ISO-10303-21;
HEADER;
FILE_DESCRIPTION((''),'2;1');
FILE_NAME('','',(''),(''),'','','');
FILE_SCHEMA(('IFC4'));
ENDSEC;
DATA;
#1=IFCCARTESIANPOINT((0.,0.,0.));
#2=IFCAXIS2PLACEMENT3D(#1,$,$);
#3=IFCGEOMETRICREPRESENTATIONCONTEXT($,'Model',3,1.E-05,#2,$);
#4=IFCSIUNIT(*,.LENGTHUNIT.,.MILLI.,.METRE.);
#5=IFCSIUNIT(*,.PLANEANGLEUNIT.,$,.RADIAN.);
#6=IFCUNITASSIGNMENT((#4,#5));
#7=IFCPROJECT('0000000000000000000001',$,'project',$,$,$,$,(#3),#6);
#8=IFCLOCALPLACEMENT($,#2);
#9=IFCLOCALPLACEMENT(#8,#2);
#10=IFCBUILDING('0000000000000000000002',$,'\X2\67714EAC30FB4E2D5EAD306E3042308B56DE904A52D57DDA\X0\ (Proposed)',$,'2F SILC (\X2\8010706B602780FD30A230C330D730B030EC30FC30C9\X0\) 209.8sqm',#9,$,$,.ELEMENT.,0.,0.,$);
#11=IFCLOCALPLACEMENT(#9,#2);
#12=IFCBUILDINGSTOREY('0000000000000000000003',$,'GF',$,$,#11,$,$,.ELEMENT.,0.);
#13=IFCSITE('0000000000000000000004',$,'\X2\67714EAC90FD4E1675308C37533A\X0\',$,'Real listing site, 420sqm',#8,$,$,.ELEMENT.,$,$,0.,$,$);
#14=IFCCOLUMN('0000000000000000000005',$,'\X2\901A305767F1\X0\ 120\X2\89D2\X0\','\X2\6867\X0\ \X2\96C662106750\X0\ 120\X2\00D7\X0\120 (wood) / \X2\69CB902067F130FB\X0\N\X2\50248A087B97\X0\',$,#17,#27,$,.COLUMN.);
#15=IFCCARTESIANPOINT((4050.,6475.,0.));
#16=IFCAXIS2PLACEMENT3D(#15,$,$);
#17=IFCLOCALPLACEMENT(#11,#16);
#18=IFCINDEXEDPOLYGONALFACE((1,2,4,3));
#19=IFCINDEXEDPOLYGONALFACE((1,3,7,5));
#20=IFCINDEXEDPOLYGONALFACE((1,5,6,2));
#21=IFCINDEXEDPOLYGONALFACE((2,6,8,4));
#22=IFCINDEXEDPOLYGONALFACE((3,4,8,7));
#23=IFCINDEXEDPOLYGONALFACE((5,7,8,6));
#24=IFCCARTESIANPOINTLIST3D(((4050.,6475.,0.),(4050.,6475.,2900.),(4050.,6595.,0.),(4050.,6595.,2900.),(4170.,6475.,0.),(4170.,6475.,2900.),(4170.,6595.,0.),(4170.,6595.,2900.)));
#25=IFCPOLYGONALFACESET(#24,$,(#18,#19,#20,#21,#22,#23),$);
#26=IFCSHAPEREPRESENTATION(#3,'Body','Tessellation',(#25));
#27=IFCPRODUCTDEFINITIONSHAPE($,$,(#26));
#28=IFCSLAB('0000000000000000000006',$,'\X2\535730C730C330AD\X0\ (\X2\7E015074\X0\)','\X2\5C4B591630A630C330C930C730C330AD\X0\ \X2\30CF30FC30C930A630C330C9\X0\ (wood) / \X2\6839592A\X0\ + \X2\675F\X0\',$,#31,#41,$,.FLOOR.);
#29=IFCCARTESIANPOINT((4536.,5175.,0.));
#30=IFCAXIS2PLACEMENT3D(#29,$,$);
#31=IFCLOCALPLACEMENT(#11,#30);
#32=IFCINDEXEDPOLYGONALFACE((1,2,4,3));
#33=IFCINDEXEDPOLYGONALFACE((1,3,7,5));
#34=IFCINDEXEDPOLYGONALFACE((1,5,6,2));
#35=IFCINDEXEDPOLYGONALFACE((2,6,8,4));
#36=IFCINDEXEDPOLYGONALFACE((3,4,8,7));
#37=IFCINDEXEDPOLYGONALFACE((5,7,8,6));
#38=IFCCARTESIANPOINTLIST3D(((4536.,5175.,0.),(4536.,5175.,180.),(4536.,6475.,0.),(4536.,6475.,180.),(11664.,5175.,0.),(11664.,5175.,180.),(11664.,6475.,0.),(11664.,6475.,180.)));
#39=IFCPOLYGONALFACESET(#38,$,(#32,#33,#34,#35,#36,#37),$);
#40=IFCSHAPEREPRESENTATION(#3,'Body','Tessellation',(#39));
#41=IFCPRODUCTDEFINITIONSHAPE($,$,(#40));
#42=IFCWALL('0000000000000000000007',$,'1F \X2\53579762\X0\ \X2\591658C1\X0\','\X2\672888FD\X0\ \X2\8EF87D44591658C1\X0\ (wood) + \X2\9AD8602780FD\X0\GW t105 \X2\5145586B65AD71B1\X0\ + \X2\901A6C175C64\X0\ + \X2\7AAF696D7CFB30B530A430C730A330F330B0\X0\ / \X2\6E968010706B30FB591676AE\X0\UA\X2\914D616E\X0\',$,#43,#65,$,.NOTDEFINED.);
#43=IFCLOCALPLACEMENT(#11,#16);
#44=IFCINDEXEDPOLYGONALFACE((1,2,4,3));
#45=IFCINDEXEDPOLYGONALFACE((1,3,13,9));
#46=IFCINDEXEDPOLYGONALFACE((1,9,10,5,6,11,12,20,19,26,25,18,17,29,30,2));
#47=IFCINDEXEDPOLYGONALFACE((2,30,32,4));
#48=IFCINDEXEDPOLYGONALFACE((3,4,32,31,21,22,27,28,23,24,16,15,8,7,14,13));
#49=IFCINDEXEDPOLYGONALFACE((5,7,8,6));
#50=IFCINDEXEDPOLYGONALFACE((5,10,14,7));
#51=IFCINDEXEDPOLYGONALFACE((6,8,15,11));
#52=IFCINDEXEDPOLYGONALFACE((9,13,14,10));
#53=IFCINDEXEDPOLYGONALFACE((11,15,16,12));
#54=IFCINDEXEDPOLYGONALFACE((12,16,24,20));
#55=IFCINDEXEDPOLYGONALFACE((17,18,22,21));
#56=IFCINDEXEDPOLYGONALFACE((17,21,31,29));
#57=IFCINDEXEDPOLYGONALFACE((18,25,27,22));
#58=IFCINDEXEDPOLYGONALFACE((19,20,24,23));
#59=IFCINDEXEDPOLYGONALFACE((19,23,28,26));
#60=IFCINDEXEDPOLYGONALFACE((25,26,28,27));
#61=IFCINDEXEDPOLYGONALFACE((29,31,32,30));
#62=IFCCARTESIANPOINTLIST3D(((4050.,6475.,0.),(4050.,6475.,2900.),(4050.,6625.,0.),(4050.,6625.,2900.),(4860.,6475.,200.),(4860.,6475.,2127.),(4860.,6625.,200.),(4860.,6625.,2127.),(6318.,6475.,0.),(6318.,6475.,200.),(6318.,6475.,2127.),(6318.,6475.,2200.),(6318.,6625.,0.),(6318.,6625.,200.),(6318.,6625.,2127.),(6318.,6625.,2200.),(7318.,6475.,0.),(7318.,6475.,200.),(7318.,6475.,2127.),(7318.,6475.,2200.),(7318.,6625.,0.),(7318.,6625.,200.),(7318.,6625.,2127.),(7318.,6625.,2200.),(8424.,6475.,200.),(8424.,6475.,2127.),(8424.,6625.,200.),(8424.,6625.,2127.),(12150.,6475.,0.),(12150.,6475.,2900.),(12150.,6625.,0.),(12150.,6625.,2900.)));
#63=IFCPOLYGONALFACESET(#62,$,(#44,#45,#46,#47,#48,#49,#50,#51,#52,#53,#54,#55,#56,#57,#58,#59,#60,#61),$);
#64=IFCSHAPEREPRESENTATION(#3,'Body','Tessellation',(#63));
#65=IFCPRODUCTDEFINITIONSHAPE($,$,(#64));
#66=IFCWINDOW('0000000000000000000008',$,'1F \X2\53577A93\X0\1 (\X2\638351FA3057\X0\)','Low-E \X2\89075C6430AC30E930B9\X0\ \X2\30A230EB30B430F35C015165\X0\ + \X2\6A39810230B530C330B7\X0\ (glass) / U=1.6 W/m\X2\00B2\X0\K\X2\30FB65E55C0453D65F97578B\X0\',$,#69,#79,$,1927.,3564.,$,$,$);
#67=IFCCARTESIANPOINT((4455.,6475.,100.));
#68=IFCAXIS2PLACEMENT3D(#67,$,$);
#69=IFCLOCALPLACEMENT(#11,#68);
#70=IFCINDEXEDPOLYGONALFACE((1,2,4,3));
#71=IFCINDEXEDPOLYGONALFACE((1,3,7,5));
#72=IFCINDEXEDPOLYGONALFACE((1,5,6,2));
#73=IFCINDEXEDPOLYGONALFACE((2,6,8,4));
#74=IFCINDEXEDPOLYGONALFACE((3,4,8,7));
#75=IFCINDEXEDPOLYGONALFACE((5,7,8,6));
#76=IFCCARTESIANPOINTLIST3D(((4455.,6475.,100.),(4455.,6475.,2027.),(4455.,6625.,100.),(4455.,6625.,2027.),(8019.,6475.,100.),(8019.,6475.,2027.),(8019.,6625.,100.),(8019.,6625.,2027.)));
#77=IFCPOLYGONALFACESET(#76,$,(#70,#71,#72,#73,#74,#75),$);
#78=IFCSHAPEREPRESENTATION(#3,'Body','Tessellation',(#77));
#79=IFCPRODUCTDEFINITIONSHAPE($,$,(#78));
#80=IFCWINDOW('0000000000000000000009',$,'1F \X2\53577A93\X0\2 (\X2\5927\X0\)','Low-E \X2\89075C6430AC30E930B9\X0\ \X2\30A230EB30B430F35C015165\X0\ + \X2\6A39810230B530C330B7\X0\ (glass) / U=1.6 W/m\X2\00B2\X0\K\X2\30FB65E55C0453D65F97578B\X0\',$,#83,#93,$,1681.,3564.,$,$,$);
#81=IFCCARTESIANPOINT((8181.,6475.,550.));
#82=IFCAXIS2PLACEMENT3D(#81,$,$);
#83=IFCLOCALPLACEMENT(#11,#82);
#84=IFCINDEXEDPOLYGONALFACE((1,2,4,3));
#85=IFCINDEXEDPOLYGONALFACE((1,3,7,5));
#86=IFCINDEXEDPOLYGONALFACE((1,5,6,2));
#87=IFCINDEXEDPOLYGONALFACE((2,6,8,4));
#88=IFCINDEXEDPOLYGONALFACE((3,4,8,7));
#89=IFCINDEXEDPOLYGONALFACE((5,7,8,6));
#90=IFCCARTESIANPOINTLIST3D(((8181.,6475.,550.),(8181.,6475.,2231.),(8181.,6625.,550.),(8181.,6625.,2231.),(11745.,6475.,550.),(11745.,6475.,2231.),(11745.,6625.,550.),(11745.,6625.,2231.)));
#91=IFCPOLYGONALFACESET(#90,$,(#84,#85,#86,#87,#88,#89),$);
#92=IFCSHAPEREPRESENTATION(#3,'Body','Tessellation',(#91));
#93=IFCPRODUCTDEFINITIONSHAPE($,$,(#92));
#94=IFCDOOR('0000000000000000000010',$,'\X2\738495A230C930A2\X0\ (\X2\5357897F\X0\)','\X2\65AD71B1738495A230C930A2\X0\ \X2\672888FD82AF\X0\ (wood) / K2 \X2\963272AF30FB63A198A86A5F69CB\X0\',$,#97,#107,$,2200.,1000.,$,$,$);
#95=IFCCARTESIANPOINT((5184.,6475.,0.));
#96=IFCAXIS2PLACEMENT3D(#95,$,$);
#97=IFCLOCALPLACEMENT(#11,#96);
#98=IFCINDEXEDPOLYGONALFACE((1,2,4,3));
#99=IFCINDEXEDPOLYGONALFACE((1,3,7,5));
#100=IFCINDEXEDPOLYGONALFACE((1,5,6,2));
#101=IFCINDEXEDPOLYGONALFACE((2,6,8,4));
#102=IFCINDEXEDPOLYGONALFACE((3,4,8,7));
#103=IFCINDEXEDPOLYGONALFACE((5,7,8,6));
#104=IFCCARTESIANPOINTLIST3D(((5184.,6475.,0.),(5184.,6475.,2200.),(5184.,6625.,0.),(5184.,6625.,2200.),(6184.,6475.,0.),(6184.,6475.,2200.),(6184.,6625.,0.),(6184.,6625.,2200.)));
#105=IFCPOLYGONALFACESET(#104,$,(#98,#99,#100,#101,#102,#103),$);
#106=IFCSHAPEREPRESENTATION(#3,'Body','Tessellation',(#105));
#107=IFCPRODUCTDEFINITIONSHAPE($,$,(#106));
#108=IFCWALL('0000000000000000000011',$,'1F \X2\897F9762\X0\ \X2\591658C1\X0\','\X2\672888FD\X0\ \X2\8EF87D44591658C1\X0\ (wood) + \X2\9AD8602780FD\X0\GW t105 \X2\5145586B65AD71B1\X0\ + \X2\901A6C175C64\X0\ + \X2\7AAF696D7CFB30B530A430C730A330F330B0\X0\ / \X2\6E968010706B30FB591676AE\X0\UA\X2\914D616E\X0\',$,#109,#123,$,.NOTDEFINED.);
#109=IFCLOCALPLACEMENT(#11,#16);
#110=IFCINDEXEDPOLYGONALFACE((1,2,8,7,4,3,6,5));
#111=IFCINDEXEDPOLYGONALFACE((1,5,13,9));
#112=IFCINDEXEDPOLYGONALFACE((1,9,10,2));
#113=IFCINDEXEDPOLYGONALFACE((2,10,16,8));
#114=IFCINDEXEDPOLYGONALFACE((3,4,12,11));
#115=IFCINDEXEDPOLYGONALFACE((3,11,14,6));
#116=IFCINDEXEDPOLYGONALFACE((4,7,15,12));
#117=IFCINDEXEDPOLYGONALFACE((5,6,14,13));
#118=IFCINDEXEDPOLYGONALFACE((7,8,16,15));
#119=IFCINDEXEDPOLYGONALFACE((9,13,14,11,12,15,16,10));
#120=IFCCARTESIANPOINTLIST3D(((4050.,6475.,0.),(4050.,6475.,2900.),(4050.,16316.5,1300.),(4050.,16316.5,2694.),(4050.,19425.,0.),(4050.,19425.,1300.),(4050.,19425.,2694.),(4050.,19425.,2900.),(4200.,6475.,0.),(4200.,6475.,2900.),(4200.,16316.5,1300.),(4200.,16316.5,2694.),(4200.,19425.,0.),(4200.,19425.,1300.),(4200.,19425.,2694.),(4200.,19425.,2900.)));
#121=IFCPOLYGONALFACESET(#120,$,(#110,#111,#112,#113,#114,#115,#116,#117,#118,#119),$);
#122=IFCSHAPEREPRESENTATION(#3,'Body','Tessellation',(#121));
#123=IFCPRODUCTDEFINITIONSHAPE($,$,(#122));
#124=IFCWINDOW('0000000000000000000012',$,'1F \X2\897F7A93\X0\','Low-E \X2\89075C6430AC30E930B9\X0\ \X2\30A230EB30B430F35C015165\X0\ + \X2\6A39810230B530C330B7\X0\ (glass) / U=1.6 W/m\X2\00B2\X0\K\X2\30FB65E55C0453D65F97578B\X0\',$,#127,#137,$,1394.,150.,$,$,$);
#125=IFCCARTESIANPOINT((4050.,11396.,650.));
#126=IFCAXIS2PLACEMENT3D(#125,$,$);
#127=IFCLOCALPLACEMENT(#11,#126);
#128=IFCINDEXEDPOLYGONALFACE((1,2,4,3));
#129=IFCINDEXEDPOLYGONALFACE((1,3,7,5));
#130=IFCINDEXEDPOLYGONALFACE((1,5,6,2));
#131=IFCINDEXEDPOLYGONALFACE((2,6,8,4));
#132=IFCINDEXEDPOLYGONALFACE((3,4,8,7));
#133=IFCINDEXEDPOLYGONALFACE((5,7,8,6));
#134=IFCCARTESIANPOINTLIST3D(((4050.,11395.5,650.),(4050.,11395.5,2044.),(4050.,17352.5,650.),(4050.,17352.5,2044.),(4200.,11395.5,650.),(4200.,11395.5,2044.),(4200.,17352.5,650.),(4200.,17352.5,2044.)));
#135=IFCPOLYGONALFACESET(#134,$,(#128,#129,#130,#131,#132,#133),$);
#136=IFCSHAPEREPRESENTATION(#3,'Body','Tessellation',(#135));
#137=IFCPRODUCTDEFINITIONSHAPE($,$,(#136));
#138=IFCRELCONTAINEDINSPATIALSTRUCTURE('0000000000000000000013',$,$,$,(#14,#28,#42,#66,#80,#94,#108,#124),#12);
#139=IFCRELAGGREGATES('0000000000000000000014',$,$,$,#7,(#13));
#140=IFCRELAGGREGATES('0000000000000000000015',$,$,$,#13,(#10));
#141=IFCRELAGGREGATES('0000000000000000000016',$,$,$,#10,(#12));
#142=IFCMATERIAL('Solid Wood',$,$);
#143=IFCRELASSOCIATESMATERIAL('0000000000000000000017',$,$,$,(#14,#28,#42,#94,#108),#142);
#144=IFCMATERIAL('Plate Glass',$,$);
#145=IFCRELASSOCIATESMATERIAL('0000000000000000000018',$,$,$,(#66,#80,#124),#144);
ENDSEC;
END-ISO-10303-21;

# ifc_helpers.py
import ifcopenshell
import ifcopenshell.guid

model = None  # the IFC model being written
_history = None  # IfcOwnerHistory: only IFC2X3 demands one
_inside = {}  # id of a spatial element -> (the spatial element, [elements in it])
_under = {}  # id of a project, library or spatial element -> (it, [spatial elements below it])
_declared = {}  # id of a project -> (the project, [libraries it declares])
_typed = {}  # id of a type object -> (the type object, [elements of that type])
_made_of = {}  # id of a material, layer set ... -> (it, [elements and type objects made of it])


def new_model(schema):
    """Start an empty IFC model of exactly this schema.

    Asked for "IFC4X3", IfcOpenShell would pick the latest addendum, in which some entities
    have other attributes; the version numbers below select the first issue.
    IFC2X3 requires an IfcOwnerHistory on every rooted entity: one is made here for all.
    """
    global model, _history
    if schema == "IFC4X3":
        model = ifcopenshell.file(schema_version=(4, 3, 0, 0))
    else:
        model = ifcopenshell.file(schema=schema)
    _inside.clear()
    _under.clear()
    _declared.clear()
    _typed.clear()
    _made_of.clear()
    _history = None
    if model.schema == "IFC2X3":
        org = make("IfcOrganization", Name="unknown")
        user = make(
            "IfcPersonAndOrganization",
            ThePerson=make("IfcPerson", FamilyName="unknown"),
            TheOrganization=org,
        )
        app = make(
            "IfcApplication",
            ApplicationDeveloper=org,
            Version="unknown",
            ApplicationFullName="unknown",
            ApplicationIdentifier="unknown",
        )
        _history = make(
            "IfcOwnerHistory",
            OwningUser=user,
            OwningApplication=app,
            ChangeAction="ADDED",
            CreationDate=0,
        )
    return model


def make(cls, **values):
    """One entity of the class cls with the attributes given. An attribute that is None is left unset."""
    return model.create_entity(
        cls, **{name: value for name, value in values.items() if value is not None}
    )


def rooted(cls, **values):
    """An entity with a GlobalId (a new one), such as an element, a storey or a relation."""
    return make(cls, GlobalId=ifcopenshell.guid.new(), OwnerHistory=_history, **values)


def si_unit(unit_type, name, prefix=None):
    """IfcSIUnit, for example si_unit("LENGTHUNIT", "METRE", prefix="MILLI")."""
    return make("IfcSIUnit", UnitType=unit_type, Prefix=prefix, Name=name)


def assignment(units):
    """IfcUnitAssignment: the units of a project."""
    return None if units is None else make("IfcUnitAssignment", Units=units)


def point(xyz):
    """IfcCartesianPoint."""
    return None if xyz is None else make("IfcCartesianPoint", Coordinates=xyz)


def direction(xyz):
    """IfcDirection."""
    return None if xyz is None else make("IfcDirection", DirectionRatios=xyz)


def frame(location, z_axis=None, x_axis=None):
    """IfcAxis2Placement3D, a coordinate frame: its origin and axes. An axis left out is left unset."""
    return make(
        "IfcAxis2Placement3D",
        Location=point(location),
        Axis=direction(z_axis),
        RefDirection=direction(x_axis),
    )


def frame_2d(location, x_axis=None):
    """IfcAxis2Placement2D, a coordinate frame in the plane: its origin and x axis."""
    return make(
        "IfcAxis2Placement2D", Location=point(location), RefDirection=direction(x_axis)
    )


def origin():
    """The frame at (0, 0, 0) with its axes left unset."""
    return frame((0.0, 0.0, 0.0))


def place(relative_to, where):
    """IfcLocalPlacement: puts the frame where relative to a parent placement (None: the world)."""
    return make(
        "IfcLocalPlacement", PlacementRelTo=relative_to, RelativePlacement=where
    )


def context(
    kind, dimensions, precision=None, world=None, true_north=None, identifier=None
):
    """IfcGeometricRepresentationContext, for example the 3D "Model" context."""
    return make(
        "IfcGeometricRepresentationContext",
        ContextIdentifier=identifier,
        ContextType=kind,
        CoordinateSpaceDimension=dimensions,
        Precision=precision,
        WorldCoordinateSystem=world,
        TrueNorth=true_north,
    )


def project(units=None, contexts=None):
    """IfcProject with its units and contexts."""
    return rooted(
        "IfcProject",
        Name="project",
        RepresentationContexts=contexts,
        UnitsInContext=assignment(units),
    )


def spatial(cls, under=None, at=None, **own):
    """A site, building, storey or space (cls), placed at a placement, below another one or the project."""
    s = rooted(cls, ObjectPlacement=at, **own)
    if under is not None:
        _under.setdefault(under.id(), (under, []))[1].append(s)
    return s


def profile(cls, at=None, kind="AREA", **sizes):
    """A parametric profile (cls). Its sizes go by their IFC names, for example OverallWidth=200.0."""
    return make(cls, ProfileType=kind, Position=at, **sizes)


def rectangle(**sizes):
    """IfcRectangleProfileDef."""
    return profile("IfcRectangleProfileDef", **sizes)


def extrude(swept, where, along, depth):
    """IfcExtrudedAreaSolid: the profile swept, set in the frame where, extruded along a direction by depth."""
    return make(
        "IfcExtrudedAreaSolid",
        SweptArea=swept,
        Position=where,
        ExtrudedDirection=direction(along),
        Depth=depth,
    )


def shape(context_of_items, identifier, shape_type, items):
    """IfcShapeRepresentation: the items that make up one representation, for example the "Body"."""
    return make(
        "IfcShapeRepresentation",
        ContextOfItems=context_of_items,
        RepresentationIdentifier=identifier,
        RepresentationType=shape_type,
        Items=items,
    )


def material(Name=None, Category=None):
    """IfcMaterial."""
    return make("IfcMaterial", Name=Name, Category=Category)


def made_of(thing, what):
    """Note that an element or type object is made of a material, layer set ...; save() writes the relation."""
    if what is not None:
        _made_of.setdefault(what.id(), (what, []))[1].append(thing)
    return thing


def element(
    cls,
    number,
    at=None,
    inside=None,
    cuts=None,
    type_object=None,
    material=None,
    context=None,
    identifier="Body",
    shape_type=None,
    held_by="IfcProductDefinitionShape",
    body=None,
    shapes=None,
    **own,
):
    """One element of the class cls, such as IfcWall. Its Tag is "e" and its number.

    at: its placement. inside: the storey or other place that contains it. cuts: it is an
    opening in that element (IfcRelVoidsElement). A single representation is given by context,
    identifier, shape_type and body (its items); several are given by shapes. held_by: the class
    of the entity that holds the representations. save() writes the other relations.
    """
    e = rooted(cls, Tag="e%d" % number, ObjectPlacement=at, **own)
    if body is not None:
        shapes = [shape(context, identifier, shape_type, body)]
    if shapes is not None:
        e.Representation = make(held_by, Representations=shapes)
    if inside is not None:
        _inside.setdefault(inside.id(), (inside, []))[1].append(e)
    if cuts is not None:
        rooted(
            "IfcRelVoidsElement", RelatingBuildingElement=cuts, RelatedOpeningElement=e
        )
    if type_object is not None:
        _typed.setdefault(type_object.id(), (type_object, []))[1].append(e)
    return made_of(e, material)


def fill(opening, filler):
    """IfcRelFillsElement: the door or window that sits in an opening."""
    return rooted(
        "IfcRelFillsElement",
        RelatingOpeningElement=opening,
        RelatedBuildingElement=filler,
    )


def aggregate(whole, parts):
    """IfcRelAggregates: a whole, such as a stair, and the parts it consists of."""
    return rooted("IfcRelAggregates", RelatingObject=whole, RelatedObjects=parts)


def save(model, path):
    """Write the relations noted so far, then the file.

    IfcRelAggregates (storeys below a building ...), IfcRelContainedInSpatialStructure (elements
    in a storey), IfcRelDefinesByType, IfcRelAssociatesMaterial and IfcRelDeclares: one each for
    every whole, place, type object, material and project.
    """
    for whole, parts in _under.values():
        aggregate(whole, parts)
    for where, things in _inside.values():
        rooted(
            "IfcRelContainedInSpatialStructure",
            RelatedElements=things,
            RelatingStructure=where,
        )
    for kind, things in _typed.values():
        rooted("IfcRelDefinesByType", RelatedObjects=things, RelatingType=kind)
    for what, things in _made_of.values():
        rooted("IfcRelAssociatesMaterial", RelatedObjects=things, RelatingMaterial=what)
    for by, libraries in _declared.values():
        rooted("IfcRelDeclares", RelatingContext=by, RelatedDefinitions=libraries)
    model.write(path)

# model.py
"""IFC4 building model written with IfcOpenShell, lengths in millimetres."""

from ifc_helpers import new_model, si_unit, frame, frame_2d, origin, place, context, project, spatial, rectangle, extrude, material, element, fill, save


model = new_model("IFC4")

# Units and contexts
model_context = context("Model", 3, precision=1e-05, world=origin())
ifc_project = project(units=[si_unit("LENGTHUNIT", "METRE", prefix="MILLI"), si_unit("PLANEANGLEUNIT", "RADIAN")], contexts=[model_context])

# Site, building, storey
site_placement = place(None, origin())
site = spatial("IfcSite", under=ifc_project, at=site_placement, Name="東京都世田谷区", ObjectType="Real listing site, 420sqm", CompositionType="ELEMENT", RefElevation=0.0)
building_placement = place(site_placement, origin())
building = spatial("IfcBuilding", under=site, at=building_placement, Name="東京・中庭のある回遊動線 (Proposed)", ObjectType="2F SILC (耐火性能アップグレード) 209.8sqm", CompositionType="ELEMENT", ElevationOfRefHeight=0.0, ElevationOfTerrain=0.0)
storey_placement = place(building_placement, origin())
storey = spatial("IfcBuildingStorey", under=building, at=storey_placement, Name="GF", CompositionType="ELEMENT", Elevation=0.0)

# Column
ifc_material_1 = material(Name="Solid Wood")
column_placement = place(storey_placement, frame((4050.0, 6475.0, 0.0)))
element("IfcColumn", 1, at=column_placement, inside=storey, material=ifc_material_1, Name="通し柱 120角", Description="桧 集成材 120×120 (wood) / 構造柱・N値計算", PredefinedType="COLUMN", context=model_context, shape_type="SweptSolid", body=[
    extrude(rectangle(XDim=120.0, YDim=120.0, at=frame_2d((60.0, 60.0))), frame((4050.0, 6475.0, 0.0)), (0.0, 0.0, 1.0), 2900.0),
])

# Slab
slab_1_placement = place(storey_placement, frame((4536.0, 5175.0, 0.0)))
element("IfcSlab", 2, at=slab_1_placement, inside=storey, material=ifc_material_1, Name="南デッキ (縁側)", Description="屋外ウッドデッキ ハードウッド (wood) / 根太 + 束", PredefinedType="FLOOR", context=model_context, shape_type="SweptSolid", body=[
    extrude(rectangle(XDim=7128.0, YDim=1300.0, at=frame_2d((3564.0, 650.0))), frame((4536.0, 5175.0, 0.0)), (0.0, 0.0, 1.0), 180.0),
])

# Wall, openings, windows, door
wall_1_placement = place(storey_placement, frame((4050.0, 6475.0, 0.0)))
wall_1 = element("IfcWall", 3, at=wall_1_placement, inside=storey, material=ifc_material_1, Name="1F 南面 外壁", Description="木製 軸組外壁 (wood) + 高性能GW t105 充填断熱 + 通気層 + 窯業系サイディング / 準耐火・外皮UA配慮", PredefinedType="NOTDEFINED", context=model_context, shape_type="SweptSolid", body=[
    extrude(rectangle(XDim=8100.0, YDim=150.0, at=frame_2d((4050.0, 75.0))), frame((4050.0, 6475.0, 0.0)), (0.0, 0.0, 1.0), 2900.0),
])
opening_1_placement = place(storey_placement, frame((4455.0, 6475.0, 100.0)))
opening_1 = element("IfcOpeningElement", 4, at=opening_1_placement, cuts=wall_1, PredefinedType="NOTDEFINED", context=model_context, shape_type="SweptSolid", body=[
    extrude(rectangle(XDim=3564.0, YDim=150.0, at=frame_2d((1782.0, 75.0))), frame((4455.0, 6475.0, 100.0)), (0.0, 0.0, 1.0), 1927.0),
])
opening_2_placement = place(storey_placement, frame((8181.0, 6475.0, 550.0)))
opening_2 = element("IfcOpeningElement", 5, at=opening_2_placement, cuts=wall_1, PredefinedType="NOTDEFINED", context=model_context, shape_type="SweptSolid", body=[
    extrude(rectangle(XDim=3564.0, YDim=150.0, at=frame_2d((1782.0, 75.0))), frame((8181.0, 6475.0, 550.0)), (0.0, 0.0, 1.0), 1681.0),
])
opening_3_placement = place(storey_placement, frame((5184.0, 6475.0, 0.0)))
opening_3 = element("IfcOpeningElement", 6, at=opening_3_placement, cuts=wall_1, PredefinedType="NOTDEFINED", context=model_context, shape_type="SweptSolid", body=[
    extrude(rectangle(XDim=1000.0, YDim=150.0, at=frame_2d((500.0, 75.0))), frame((5184.0, 6475.0, 0.0)), (0.0, 0.0, 1.0), 2200.0),
])
ifc_material_2 = material(Name="Plate Glass")
window_1_placement = place(storey_placement, frame((4455.0, 6475.0, 100.0)))
window_1 = element("IfcWindow", 7, at=window_1_placement, inside=storey, material=ifc_material_2, Name="1F 南窓1 (掃出し)", Description="Low-E 複層ガラス アルゴン封入 + 樹脂サッシ (glass) / U=1.6 W/m²K・日射取得型", OverallHeight=1927.0, OverallWidth=3564.0, context=model_context, shape_type="SweptSolid", body=[
    extrude(rectangle(XDim=3564.0, YDim=150.0, at=frame_2d((1782.0, 75.0))), frame((4455.0, 6475.0, 100.0)), (0.0, 0.0, 1.0), 1927.0),
])
fill(opening_1, window_1)
window_2_placement = place(storey_placement, frame((8181.0, 6475.0, 550.0)))
window_2 = element("IfcWindow", 8, at=window_2_placement, inside=storey, material=ifc_material_2, Name="1F 南窓2 (大)", Description="Low-E 複層ガラス アルゴン封入 + 樹脂サッシ (glass) / U=1.6 W/m²K・日射取得型", OverallHeight=1681.0, OverallWidth=3564.0, context=model_context, shape_type="SweptSolid", body=[
    extrude(rectangle(XDim=3564.0, YDim=150.0, at=frame_2d((1782.0, 75.0))), frame((8181.0, 6475.0, 550.0)), (0.0, 0.0, 1.0), 1681.0),
])
fill(opening_2, window_2)
door_placement = place(storey_placement, frame((5184.0, 6475.0, 0.0)))
door = element("IfcDoor", 9, at=door_placement, inside=storey, material=ifc_material_1, Name="玄関ドア (南西)", Description="断熱玄関ドア 木製芯 (wood) / K2 防犯・採風機構", OverallHeight=2200.0, OverallWidth=1000.0, context=model_context, shape_type="SweptSolid", body=[
    extrude(rectangle(XDim=1000.0, YDim=150.0, at=frame_2d((500.0, 75.0))), frame((5184.0, 6475.0, 0.0)), (0.0, 0.0, 1.0), 2200.0),
])
fill(opening_3, door)

# Wall, opening, window
wall_2_placement = place(storey_placement, frame((4050.0, 6475.0, 0.0)))
wall_2 = element("IfcWall", 10, at=wall_2_placement, inside=storey, material=ifc_material_1, Name="1F 西面 外壁", Description="木製 軸組外壁 (wood) + 高性能GW t105 充填断熱 + 通気層 + 窯業系サイディング / 準耐火・外皮UA配慮", PredefinedType="NOTDEFINED", context=model_context, shape_type="SweptSolid", body=[
    extrude(rectangle(XDim=150.0, YDim=12950.0, at=frame_2d((75.0, 6475.0))), frame((4050.0, 6475.0, 0.0)), (0.0, 0.0, 1.0), 2900.0),
])
opening_4_placement = place(storey_placement, frame((4050.0, 11396.0, 650.0)))
opening_4 = element("IfcOpeningElement", 11, at=opening_4_placement, cuts=wall_2, PredefinedType="NOTDEFINED", context=model_context, shape_type="SweptSolid", body=[
    extrude(rectangle(XDim=150.0, YDim=5957.0, at=frame_2d((75.0, 2978.0))), frame((4050.0, 11396.0, 650.0)), (0.0, 0.0, 1.0), 1394.0),
])
window_3_placement = place(storey_placement, frame((4050.0, 11396.0, 650.0)))
window_3 = element("IfcWindow", 12, at=window_3_placement, inside=storey, material=ifc_material_2, Name="1F 西窓", Description="Low-E 複層ガラス アルゴン封入 + 樹脂サッシ (glass) / U=1.6 W/m²K・日射取得型", OverallHeight=1394.0, OverallWidth=150.0, context=model_context, shape_type="SweptSolid", body=[
    extrude(rectangle(XDim=150.0, YDim=5957.0, at=frame_2d((75.0, 2978.0))), frame((4050.0, 11396.0, 650.0)), (0.0, 0.0, 1.0), 1394.0),
])
fill(opening_4, window_3)

save(model, "model.ifc")
